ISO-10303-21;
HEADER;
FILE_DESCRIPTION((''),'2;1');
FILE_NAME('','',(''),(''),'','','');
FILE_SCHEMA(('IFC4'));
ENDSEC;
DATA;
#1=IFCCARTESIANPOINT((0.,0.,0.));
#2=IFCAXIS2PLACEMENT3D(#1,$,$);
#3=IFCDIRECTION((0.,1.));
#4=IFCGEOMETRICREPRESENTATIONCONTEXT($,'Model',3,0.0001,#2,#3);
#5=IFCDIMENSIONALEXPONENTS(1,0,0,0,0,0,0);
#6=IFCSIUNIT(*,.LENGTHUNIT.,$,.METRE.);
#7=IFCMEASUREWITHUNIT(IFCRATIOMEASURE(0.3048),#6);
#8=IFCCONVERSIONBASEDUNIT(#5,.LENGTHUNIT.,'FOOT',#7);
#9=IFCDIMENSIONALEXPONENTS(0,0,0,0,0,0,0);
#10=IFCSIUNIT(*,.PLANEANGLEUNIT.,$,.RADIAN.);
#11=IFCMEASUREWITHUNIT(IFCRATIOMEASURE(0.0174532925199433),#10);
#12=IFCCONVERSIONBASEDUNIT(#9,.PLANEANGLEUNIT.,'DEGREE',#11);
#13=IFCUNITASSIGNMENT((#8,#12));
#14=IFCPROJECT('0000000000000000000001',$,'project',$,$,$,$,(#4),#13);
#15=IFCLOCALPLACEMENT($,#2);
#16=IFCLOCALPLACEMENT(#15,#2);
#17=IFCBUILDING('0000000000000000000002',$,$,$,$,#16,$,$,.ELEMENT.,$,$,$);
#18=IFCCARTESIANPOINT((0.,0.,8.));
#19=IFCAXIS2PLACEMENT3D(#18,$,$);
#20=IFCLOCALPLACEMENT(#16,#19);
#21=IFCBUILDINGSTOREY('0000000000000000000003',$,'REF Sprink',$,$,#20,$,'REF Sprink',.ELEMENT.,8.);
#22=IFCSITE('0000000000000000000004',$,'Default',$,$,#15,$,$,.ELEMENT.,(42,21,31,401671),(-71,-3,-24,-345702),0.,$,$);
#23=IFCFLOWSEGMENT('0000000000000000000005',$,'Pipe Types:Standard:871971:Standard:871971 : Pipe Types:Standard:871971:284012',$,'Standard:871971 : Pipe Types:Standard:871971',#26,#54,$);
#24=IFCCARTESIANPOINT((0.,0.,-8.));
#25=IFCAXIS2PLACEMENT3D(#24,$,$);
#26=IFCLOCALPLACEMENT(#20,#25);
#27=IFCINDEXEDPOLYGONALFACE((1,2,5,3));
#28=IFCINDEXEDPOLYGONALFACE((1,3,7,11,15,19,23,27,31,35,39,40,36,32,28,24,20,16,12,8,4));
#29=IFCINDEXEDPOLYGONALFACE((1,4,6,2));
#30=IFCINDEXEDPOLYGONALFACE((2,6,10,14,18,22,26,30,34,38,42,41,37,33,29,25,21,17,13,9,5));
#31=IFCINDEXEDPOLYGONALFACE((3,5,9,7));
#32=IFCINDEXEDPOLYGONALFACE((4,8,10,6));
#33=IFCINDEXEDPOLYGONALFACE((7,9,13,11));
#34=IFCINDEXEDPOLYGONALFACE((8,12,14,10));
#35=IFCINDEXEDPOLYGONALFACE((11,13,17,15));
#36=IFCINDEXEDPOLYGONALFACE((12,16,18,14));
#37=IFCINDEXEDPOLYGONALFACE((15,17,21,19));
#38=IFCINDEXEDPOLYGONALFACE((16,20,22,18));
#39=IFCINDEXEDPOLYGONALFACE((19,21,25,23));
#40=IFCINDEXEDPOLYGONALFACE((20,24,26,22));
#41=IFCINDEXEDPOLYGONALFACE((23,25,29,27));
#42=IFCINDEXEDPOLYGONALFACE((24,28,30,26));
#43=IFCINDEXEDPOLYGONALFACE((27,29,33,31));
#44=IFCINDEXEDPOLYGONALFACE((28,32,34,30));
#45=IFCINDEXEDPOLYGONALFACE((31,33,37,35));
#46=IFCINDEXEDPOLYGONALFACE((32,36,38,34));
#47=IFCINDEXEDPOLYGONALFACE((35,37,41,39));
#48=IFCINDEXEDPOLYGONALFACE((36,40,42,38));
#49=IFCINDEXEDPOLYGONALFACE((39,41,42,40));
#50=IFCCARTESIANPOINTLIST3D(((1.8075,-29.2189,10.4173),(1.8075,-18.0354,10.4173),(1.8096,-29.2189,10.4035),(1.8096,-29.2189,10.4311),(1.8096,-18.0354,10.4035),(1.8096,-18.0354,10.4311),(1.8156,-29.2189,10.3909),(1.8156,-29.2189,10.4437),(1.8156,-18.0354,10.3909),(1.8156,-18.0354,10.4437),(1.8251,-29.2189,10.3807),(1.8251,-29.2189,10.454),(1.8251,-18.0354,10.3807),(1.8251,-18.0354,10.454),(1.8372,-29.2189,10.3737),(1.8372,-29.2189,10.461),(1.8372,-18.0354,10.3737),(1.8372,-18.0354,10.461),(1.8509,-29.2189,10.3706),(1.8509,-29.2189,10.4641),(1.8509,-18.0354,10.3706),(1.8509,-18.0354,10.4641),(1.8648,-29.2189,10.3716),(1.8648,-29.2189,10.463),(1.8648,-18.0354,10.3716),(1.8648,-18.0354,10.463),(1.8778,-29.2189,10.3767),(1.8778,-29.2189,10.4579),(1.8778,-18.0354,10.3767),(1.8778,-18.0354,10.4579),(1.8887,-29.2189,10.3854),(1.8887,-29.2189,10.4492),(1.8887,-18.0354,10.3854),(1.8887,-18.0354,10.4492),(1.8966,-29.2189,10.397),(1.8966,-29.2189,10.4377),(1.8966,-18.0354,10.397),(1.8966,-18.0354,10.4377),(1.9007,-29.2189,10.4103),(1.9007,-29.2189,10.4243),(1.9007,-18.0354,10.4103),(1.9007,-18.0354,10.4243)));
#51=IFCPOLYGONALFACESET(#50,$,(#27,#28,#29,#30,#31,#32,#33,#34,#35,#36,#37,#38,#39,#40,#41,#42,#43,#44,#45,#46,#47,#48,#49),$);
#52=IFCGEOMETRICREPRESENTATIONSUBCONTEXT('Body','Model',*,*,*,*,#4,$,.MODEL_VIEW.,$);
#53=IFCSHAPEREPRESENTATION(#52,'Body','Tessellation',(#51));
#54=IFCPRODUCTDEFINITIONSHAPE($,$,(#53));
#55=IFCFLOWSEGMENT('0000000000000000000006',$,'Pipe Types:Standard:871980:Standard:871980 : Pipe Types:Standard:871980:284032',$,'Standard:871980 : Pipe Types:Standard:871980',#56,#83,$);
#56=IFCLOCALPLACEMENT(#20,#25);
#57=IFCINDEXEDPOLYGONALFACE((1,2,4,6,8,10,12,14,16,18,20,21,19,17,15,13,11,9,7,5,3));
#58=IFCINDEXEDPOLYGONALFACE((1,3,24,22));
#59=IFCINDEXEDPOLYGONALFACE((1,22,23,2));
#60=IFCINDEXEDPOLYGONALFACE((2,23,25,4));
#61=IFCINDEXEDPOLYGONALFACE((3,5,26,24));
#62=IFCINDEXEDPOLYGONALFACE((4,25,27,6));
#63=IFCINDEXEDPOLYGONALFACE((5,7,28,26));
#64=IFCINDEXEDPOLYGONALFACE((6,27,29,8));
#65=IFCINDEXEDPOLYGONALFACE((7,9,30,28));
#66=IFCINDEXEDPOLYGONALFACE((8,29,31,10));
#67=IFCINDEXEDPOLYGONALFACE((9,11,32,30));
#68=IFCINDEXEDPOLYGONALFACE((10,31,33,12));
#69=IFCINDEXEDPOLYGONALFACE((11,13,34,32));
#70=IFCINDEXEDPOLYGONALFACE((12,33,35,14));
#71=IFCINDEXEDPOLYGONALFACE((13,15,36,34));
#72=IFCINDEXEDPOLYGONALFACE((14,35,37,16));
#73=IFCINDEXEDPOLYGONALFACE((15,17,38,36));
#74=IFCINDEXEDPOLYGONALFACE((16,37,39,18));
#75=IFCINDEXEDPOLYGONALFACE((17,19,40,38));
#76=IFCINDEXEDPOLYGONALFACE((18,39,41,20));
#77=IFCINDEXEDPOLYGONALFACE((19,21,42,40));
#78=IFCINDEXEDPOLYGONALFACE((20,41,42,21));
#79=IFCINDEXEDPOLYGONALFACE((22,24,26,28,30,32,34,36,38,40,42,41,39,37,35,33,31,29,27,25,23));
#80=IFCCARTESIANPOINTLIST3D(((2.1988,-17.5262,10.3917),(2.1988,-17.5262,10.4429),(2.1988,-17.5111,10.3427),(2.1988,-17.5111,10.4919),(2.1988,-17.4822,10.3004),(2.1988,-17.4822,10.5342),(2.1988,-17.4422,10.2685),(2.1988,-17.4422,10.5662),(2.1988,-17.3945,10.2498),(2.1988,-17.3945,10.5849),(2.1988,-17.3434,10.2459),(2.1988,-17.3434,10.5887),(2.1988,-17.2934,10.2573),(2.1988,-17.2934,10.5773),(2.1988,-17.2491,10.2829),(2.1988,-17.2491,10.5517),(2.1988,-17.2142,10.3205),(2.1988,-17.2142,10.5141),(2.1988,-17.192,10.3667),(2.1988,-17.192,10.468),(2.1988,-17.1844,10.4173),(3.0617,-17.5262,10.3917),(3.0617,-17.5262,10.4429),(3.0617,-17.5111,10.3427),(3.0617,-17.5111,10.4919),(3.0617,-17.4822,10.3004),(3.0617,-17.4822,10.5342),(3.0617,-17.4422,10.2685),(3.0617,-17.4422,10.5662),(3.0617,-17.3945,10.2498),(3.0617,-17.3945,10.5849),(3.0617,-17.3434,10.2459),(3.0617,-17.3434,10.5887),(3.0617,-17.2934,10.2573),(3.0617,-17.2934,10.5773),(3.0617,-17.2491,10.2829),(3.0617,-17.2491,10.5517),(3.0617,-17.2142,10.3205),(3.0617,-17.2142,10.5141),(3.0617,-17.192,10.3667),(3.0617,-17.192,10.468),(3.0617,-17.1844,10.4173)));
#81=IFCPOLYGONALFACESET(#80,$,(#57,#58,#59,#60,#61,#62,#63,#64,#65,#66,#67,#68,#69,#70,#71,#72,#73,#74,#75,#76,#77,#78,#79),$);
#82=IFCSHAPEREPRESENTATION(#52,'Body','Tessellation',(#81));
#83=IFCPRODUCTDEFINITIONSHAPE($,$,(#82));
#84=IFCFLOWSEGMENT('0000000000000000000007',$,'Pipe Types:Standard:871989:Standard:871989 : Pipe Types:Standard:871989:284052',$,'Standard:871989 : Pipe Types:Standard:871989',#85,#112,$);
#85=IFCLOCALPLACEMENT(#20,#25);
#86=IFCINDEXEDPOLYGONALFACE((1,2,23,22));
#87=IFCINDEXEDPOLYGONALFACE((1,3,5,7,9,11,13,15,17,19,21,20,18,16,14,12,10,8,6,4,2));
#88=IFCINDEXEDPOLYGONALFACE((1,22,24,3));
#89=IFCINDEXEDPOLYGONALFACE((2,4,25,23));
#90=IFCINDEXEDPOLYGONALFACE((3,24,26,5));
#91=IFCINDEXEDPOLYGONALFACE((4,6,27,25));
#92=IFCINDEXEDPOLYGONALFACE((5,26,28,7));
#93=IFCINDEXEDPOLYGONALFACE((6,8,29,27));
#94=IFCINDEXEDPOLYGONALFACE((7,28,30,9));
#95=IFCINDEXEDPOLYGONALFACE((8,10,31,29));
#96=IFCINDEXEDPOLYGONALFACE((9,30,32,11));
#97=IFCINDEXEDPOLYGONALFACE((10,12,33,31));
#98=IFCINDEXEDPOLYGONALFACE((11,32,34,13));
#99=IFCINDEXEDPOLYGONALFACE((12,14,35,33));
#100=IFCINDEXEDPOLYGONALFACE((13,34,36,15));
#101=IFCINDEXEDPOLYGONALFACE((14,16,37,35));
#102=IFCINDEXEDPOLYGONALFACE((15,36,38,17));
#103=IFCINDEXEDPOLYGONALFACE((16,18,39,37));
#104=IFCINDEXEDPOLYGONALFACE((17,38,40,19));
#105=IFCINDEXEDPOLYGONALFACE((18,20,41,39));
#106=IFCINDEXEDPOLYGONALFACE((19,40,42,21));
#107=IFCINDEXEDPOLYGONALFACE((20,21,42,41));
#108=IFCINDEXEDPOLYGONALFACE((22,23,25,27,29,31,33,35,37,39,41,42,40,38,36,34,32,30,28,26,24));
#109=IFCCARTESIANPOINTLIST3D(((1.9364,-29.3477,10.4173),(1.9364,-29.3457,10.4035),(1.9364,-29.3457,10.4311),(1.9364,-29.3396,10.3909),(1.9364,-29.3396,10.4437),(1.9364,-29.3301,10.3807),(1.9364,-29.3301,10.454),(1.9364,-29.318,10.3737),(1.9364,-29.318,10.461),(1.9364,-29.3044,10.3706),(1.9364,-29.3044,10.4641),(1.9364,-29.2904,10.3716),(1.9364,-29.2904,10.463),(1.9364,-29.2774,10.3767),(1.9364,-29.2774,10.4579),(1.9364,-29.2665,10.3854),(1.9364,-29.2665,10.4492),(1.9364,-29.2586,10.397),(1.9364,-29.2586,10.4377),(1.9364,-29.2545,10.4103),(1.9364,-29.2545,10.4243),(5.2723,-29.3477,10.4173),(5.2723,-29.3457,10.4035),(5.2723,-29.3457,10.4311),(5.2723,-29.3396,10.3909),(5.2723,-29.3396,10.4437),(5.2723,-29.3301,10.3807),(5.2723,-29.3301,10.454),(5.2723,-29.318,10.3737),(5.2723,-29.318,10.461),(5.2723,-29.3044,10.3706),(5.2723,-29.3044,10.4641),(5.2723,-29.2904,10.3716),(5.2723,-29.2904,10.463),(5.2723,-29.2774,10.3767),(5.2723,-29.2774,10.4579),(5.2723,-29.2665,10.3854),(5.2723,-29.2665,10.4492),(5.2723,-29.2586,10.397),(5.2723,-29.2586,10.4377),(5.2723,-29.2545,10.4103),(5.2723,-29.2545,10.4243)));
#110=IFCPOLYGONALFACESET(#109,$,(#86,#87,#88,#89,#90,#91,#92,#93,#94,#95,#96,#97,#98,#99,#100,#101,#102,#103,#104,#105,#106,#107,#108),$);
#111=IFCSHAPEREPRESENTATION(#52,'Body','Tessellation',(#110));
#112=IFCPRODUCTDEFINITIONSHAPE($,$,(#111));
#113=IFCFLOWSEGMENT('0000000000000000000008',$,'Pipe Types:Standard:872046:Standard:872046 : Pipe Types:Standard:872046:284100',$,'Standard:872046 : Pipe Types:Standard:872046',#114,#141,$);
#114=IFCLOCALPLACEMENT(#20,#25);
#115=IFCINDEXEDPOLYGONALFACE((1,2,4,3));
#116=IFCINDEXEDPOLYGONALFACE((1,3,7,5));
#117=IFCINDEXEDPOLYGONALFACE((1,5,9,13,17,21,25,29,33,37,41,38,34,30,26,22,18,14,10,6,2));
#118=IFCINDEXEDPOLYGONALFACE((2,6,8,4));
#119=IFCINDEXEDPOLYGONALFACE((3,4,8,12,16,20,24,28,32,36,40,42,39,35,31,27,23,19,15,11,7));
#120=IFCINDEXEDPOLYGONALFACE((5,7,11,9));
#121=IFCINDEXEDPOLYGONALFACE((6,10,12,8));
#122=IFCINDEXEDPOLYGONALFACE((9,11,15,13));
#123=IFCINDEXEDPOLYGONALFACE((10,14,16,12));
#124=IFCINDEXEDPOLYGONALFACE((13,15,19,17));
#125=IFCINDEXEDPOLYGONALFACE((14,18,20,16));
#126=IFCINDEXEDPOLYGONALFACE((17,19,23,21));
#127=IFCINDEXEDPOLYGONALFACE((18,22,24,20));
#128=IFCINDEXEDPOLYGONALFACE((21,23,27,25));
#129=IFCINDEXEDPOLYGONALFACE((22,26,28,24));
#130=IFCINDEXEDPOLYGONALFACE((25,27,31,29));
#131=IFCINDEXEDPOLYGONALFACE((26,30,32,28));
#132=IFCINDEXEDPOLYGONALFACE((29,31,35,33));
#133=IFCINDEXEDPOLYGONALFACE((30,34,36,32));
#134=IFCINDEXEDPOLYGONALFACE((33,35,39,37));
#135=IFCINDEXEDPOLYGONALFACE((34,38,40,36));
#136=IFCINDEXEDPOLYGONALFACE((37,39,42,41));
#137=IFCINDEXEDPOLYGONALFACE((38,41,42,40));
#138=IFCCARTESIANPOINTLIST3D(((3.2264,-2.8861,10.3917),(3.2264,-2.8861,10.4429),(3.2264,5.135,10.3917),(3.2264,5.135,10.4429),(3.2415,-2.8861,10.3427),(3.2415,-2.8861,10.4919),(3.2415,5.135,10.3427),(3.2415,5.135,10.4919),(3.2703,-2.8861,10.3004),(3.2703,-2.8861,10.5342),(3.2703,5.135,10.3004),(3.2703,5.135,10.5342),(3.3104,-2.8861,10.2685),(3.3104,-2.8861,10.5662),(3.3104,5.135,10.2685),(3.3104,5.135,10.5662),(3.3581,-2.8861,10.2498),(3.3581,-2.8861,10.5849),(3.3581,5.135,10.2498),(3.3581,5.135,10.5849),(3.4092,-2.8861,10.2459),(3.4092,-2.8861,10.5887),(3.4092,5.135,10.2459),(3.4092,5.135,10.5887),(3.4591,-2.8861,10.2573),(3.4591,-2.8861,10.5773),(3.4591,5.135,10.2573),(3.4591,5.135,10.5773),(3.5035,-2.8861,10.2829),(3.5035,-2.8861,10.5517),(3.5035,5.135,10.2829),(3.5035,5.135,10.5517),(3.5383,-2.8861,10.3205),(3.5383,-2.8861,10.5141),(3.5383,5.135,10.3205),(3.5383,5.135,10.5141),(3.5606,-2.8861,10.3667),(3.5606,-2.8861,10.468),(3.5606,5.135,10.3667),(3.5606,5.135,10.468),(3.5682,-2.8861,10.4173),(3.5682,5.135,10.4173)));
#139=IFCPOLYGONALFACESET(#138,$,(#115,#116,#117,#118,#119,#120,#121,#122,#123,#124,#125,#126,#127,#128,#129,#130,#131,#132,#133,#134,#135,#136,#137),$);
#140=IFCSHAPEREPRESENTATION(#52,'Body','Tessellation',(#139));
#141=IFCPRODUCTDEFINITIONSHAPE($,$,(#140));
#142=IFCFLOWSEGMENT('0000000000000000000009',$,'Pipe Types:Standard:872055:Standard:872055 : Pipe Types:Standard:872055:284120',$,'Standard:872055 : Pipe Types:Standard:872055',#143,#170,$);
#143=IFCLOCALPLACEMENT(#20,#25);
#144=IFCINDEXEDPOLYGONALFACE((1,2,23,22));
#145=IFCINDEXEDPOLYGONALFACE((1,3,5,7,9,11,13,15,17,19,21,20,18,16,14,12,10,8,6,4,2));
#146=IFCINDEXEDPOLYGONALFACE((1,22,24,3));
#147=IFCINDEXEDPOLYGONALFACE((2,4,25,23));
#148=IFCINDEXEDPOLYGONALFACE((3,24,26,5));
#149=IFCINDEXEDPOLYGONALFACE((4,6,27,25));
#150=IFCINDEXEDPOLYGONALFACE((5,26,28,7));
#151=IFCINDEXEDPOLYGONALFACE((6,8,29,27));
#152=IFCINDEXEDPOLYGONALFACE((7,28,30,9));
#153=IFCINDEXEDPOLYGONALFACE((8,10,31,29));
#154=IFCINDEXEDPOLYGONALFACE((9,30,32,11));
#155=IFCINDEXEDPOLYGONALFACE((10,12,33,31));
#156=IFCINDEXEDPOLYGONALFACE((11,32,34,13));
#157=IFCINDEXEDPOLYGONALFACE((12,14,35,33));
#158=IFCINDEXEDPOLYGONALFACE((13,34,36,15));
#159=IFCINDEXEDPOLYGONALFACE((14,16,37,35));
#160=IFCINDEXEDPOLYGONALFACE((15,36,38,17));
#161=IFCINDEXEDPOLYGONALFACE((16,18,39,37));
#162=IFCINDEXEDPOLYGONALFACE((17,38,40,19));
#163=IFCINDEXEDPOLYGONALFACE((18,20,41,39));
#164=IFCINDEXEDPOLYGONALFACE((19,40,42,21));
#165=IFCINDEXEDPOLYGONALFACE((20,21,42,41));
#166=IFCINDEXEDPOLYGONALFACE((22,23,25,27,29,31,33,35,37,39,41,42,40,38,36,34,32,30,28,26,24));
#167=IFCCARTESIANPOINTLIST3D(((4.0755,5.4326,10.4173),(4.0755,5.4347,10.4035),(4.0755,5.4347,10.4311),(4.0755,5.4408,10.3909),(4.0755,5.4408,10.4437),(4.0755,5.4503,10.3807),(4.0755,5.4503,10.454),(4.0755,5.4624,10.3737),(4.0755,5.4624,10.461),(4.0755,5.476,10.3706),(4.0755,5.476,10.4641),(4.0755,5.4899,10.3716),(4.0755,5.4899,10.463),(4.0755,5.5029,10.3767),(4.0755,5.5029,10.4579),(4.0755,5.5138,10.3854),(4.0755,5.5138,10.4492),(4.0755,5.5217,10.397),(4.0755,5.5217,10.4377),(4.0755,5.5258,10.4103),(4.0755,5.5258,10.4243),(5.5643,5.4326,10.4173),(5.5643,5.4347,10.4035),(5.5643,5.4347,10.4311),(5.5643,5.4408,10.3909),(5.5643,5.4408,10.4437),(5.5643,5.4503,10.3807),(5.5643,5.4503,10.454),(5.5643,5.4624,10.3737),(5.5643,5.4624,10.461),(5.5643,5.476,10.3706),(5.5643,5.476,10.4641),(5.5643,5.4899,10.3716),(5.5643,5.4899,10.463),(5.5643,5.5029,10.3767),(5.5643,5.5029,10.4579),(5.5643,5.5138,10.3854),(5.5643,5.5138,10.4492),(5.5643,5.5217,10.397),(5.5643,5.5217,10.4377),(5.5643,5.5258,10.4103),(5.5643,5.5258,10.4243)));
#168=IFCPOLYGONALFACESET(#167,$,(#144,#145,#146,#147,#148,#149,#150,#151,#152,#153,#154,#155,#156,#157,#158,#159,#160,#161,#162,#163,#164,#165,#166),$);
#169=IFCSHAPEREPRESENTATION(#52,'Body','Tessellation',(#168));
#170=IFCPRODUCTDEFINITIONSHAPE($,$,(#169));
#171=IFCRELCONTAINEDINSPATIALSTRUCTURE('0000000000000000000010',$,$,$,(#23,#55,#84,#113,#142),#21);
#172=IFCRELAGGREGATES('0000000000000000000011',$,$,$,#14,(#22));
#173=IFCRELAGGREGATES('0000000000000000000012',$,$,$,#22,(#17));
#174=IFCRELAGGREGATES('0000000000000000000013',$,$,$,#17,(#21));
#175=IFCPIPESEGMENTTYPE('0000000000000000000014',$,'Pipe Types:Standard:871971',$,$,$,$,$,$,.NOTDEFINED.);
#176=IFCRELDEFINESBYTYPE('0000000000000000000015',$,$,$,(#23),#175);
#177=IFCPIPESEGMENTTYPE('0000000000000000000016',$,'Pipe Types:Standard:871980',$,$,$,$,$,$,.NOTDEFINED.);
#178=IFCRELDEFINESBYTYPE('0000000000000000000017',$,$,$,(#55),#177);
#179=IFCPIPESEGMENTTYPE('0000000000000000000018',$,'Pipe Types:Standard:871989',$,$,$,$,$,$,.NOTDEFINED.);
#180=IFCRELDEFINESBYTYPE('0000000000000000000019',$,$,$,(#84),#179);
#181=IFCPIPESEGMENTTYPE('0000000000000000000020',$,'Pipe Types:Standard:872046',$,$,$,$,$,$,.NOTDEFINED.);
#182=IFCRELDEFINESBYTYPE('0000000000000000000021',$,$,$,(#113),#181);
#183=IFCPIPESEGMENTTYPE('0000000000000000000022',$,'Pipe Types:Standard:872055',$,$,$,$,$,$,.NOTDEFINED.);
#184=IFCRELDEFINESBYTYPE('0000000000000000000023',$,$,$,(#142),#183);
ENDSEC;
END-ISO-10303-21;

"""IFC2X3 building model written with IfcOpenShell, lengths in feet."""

from ifc_helpers import new_model, entity, si_unit, converted_unit, direction, frame, origin, origin_2d_with_axis, place, context, subcontext, project, spatial, circle, extrude, source, transform, mapped, type_object, type_shapes, element, save


model = new_model("IFC2X3")

# Units and contexts
model_context = context("Model", 3, precision=0.0001, world=origin(), true_north=direction((0.0, 1.0)))
body_context = subcontext(model_context, "Body", "Model", "MODEL_VIEW")
ifc_project = project(units=[converted_unit("LENGTHUNIT", "FOOT", entity("IfcRatioMeasure", 0.3048), si_unit("LENGTHUNIT", "METRE"), dimensions=[1, 0, 0, 0, 0, 0, 0]), converted_unit("PLANEANGLEUNIT", "DEGREE", entity("IfcRatioMeasure", 0.0174532925199433), si_unit("PLANEANGLEUNIT", "RADIAN"), dimensions=[0, 0, 0, 0, 0, 0, 0])], contexts=[model_context])

# Site, building, storey
site_placement = place(None, origin())
site = spatial("IfcSite", under=ifc_project, at=site_placement, Name="Default", CompositionType="ELEMENT", RefLatitude=(42, 21, 31, 401671), RefLongitude=(-71, -3, -24, -345702), RefElevation=0.0)
building_placement = place(site_placement, origin())
building = spatial("IfcBuilding", under=site, at=building_placement, CompositionType="ELEMENT")
storey_placement = place(building_placement, frame((0.0, 0.0, 8.0)))
storey = spatial("IfcBuildingStorey", under=building, at=storey_placement, Name="REF Sprink", LongName="REF Sprink", CompositionType="ELEMENT", Elevation=8.0)

# Flow segments
pipe_segment_type_1 = type_object("IfcPipeSegmentType", Name="Pipe Types:Standard:871971", PredefinedType="NOTDEFINED")
shared_shape_1 = source(origin(), body_context, "Body", "SweptSolid", [
    extrude(circle(Radius=0.0469, at=origin_2d_with_axis()), frame((1.8544, -29.2189, 10.4173), z_axis=(0.0, 1.0, 0.0), x_axis=(-1.0, 0.0, 0.0)), (0.0, 0.0, 1.0), 11.1835),
])
type_shapes(pipe_segment_type_1, [shared_shape_1])
flow_segment_1_placement = place(storey_placement, frame((0.0, 0.0, -8.0)))
element("IfcFlowSegment", 1, at=flow_segment_1_placement, inside=storey, type_object=pipe_segment_type_1, Name="Pipe Types:Standard:871971:Standard:871971 : Pipe Types:Standard:871971:284012", ObjectType="Standard:871971 : Pipe Types:Standard:871971", context=body_context, shape_type="MappedRepresentation", body=[
    mapped(shared_shape_1, transform((0.0, 0.0, 0.0), scale=1.0)),
])
pipe_segment_type_2 = type_object("IfcPipeSegmentType", Name="Pipe Types:Standard:871980", PredefinedType="NOTDEFINED")
shared_shape_2 = source(origin(), body_context, "Body", "SweptSolid", [
    extrude(circle(Radius=0.1719, at=origin_2d_with_axis()), frame((2.1988, -17.3562, 10.4173), z_axis=(1.0, 0.0, 0.0), x_axis=(0.0, 1.0, 0.0)), (0.0, 0.0, 1.0), 0.8628),
])
type_shapes(pipe_segment_type_2, [shared_shape_2])
flow_segment_2_placement = place(storey_placement, frame((0.0, 0.0, -8.0)))
element("IfcFlowSegment", 2, at=flow_segment_2_placement, inside=storey, type_object=pipe_segment_type_2, Name="Pipe Types:Standard:871980:Standard:871980 : Pipe Types:Standard:871980:284032", ObjectType="Standard:871980 : Pipe Types:Standard:871980", context=body_context, shape_type="MappedRepresentation", body=[
    mapped(shared_shape_2, transform((0.0, 0.0, 0.0), scale=1.0)),
])
pipe_segment_type_3 = type_object("IfcPipeSegmentType", Name="Pipe Types:Standard:871989", PredefinedType="NOTDEFINED")
shared_shape_3 = source(origin(), body_context, "Body", "SweptSolid", [
    extrude(circle(Radius=0.0469, at=origin_2d_with_axis()), frame((1.9364, -29.3009, 10.4173), z_axis=(1.0, 0.0, 0.0), x_axis=(0.0, -1.0, 0.0)), (0.0, 0.0, 1.0), 3.336),
])
type_shapes(pipe_segment_type_3, [shared_shape_3])
flow_segment_3_placement = place(storey_placement, frame((0.0, 0.0, -8.0)))
element("IfcFlowSegment", 3, at=flow_segment_3_placement, inside=storey, type_object=pipe_segment_type_3, Name="Pipe Types:Standard:871989:Standard:871989 : Pipe Types:Standard:871989:284052", ObjectType="Standard:871989 : Pipe Types:Standard:871989", context=body_context, shape_type="MappedRepresentation", body=[
    mapped(shared_shape_3, transform((0.0, 0.0, 0.0), scale=1.0)),
])
pipe_segment_type_4 = type_object("IfcPipeSegmentType", Name="Pipe Types:Standard:872046", PredefinedType="NOTDEFINED")
shared_shape_4 = source(origin(), body_context, "Body", "SweptSolid", [
    extrude(circle(Radius=0.1719, at=origin_2d_with_axis()), frame((3.3963, -2.8861, 10.4173), z_axis=(0.0, 1.0, 0.0), x_axis=(1.0, 0.0, 0.0)), (0.0, 0.0, 1.0), 8.0211),
])
type_shapes(pipe_segment_type_4, [shared_shape_4])
flow_segment_4_placement = place(storey_placement, frame((0.0, 0.0, -8.0)))
element("IfcFlowSegment", 4, at=flow_segment_4_placement, inside=storey, type_object=pipe_segment_type_4, Name="Pipe Types:Standard:872046:Standard:872046 : Pipe Types:Standard:872046:284100", ObjectType="Standard:872046 : Pipe Types:Standard:872046", context=body_context, shape_type="MappedRepresentation", body=[
    mapped(shared_shape_4, transform((0.0, 0.0, 0.0), scale=1.0)),
])
pipe_segment_type_5 = type_object("IfcPipeSegmentType", Name="Pipe Types:Standard:872055", PredefinedType="NOTDEFINED")
shared_shape_5 = source(origin(), body_context, "Body", "SweptSolid", [
    extrude(circle(Radius=0.0469, at=origin_2d_with_axis()), frame((4.0755, 5.4795, 10.4173), z_axis=(1.0, 0.0, 0.0), x_axis=(0.0, -1.0, 0.0)), (0.0, 0.0, 1.0), 1.4888),
])
type_shapes(pipe_segment_type_5, [shared_shape_5])
flow_segment_5_placement = place(storey_placement, frame((0.0, 0.0, -8.0)))
element("IfcFlowSegment", 5, at=flow_segment_5_placement, inside=storey, type_object=pipe_segment_type_5, Name="Pipe Types:Standard:872055:Standard:872055 : Pipe Types:Standard:872055:284120", ObjectType="Standard:872055 : Pipe Types:Standard:872055", context=body_context, shape_type="MappedRepresentation", body=[
    mapped(shared_shape_5, transform((0.0, 0.0, 0.0), scale=1.0)),
])

save(model, "model.ifc")
